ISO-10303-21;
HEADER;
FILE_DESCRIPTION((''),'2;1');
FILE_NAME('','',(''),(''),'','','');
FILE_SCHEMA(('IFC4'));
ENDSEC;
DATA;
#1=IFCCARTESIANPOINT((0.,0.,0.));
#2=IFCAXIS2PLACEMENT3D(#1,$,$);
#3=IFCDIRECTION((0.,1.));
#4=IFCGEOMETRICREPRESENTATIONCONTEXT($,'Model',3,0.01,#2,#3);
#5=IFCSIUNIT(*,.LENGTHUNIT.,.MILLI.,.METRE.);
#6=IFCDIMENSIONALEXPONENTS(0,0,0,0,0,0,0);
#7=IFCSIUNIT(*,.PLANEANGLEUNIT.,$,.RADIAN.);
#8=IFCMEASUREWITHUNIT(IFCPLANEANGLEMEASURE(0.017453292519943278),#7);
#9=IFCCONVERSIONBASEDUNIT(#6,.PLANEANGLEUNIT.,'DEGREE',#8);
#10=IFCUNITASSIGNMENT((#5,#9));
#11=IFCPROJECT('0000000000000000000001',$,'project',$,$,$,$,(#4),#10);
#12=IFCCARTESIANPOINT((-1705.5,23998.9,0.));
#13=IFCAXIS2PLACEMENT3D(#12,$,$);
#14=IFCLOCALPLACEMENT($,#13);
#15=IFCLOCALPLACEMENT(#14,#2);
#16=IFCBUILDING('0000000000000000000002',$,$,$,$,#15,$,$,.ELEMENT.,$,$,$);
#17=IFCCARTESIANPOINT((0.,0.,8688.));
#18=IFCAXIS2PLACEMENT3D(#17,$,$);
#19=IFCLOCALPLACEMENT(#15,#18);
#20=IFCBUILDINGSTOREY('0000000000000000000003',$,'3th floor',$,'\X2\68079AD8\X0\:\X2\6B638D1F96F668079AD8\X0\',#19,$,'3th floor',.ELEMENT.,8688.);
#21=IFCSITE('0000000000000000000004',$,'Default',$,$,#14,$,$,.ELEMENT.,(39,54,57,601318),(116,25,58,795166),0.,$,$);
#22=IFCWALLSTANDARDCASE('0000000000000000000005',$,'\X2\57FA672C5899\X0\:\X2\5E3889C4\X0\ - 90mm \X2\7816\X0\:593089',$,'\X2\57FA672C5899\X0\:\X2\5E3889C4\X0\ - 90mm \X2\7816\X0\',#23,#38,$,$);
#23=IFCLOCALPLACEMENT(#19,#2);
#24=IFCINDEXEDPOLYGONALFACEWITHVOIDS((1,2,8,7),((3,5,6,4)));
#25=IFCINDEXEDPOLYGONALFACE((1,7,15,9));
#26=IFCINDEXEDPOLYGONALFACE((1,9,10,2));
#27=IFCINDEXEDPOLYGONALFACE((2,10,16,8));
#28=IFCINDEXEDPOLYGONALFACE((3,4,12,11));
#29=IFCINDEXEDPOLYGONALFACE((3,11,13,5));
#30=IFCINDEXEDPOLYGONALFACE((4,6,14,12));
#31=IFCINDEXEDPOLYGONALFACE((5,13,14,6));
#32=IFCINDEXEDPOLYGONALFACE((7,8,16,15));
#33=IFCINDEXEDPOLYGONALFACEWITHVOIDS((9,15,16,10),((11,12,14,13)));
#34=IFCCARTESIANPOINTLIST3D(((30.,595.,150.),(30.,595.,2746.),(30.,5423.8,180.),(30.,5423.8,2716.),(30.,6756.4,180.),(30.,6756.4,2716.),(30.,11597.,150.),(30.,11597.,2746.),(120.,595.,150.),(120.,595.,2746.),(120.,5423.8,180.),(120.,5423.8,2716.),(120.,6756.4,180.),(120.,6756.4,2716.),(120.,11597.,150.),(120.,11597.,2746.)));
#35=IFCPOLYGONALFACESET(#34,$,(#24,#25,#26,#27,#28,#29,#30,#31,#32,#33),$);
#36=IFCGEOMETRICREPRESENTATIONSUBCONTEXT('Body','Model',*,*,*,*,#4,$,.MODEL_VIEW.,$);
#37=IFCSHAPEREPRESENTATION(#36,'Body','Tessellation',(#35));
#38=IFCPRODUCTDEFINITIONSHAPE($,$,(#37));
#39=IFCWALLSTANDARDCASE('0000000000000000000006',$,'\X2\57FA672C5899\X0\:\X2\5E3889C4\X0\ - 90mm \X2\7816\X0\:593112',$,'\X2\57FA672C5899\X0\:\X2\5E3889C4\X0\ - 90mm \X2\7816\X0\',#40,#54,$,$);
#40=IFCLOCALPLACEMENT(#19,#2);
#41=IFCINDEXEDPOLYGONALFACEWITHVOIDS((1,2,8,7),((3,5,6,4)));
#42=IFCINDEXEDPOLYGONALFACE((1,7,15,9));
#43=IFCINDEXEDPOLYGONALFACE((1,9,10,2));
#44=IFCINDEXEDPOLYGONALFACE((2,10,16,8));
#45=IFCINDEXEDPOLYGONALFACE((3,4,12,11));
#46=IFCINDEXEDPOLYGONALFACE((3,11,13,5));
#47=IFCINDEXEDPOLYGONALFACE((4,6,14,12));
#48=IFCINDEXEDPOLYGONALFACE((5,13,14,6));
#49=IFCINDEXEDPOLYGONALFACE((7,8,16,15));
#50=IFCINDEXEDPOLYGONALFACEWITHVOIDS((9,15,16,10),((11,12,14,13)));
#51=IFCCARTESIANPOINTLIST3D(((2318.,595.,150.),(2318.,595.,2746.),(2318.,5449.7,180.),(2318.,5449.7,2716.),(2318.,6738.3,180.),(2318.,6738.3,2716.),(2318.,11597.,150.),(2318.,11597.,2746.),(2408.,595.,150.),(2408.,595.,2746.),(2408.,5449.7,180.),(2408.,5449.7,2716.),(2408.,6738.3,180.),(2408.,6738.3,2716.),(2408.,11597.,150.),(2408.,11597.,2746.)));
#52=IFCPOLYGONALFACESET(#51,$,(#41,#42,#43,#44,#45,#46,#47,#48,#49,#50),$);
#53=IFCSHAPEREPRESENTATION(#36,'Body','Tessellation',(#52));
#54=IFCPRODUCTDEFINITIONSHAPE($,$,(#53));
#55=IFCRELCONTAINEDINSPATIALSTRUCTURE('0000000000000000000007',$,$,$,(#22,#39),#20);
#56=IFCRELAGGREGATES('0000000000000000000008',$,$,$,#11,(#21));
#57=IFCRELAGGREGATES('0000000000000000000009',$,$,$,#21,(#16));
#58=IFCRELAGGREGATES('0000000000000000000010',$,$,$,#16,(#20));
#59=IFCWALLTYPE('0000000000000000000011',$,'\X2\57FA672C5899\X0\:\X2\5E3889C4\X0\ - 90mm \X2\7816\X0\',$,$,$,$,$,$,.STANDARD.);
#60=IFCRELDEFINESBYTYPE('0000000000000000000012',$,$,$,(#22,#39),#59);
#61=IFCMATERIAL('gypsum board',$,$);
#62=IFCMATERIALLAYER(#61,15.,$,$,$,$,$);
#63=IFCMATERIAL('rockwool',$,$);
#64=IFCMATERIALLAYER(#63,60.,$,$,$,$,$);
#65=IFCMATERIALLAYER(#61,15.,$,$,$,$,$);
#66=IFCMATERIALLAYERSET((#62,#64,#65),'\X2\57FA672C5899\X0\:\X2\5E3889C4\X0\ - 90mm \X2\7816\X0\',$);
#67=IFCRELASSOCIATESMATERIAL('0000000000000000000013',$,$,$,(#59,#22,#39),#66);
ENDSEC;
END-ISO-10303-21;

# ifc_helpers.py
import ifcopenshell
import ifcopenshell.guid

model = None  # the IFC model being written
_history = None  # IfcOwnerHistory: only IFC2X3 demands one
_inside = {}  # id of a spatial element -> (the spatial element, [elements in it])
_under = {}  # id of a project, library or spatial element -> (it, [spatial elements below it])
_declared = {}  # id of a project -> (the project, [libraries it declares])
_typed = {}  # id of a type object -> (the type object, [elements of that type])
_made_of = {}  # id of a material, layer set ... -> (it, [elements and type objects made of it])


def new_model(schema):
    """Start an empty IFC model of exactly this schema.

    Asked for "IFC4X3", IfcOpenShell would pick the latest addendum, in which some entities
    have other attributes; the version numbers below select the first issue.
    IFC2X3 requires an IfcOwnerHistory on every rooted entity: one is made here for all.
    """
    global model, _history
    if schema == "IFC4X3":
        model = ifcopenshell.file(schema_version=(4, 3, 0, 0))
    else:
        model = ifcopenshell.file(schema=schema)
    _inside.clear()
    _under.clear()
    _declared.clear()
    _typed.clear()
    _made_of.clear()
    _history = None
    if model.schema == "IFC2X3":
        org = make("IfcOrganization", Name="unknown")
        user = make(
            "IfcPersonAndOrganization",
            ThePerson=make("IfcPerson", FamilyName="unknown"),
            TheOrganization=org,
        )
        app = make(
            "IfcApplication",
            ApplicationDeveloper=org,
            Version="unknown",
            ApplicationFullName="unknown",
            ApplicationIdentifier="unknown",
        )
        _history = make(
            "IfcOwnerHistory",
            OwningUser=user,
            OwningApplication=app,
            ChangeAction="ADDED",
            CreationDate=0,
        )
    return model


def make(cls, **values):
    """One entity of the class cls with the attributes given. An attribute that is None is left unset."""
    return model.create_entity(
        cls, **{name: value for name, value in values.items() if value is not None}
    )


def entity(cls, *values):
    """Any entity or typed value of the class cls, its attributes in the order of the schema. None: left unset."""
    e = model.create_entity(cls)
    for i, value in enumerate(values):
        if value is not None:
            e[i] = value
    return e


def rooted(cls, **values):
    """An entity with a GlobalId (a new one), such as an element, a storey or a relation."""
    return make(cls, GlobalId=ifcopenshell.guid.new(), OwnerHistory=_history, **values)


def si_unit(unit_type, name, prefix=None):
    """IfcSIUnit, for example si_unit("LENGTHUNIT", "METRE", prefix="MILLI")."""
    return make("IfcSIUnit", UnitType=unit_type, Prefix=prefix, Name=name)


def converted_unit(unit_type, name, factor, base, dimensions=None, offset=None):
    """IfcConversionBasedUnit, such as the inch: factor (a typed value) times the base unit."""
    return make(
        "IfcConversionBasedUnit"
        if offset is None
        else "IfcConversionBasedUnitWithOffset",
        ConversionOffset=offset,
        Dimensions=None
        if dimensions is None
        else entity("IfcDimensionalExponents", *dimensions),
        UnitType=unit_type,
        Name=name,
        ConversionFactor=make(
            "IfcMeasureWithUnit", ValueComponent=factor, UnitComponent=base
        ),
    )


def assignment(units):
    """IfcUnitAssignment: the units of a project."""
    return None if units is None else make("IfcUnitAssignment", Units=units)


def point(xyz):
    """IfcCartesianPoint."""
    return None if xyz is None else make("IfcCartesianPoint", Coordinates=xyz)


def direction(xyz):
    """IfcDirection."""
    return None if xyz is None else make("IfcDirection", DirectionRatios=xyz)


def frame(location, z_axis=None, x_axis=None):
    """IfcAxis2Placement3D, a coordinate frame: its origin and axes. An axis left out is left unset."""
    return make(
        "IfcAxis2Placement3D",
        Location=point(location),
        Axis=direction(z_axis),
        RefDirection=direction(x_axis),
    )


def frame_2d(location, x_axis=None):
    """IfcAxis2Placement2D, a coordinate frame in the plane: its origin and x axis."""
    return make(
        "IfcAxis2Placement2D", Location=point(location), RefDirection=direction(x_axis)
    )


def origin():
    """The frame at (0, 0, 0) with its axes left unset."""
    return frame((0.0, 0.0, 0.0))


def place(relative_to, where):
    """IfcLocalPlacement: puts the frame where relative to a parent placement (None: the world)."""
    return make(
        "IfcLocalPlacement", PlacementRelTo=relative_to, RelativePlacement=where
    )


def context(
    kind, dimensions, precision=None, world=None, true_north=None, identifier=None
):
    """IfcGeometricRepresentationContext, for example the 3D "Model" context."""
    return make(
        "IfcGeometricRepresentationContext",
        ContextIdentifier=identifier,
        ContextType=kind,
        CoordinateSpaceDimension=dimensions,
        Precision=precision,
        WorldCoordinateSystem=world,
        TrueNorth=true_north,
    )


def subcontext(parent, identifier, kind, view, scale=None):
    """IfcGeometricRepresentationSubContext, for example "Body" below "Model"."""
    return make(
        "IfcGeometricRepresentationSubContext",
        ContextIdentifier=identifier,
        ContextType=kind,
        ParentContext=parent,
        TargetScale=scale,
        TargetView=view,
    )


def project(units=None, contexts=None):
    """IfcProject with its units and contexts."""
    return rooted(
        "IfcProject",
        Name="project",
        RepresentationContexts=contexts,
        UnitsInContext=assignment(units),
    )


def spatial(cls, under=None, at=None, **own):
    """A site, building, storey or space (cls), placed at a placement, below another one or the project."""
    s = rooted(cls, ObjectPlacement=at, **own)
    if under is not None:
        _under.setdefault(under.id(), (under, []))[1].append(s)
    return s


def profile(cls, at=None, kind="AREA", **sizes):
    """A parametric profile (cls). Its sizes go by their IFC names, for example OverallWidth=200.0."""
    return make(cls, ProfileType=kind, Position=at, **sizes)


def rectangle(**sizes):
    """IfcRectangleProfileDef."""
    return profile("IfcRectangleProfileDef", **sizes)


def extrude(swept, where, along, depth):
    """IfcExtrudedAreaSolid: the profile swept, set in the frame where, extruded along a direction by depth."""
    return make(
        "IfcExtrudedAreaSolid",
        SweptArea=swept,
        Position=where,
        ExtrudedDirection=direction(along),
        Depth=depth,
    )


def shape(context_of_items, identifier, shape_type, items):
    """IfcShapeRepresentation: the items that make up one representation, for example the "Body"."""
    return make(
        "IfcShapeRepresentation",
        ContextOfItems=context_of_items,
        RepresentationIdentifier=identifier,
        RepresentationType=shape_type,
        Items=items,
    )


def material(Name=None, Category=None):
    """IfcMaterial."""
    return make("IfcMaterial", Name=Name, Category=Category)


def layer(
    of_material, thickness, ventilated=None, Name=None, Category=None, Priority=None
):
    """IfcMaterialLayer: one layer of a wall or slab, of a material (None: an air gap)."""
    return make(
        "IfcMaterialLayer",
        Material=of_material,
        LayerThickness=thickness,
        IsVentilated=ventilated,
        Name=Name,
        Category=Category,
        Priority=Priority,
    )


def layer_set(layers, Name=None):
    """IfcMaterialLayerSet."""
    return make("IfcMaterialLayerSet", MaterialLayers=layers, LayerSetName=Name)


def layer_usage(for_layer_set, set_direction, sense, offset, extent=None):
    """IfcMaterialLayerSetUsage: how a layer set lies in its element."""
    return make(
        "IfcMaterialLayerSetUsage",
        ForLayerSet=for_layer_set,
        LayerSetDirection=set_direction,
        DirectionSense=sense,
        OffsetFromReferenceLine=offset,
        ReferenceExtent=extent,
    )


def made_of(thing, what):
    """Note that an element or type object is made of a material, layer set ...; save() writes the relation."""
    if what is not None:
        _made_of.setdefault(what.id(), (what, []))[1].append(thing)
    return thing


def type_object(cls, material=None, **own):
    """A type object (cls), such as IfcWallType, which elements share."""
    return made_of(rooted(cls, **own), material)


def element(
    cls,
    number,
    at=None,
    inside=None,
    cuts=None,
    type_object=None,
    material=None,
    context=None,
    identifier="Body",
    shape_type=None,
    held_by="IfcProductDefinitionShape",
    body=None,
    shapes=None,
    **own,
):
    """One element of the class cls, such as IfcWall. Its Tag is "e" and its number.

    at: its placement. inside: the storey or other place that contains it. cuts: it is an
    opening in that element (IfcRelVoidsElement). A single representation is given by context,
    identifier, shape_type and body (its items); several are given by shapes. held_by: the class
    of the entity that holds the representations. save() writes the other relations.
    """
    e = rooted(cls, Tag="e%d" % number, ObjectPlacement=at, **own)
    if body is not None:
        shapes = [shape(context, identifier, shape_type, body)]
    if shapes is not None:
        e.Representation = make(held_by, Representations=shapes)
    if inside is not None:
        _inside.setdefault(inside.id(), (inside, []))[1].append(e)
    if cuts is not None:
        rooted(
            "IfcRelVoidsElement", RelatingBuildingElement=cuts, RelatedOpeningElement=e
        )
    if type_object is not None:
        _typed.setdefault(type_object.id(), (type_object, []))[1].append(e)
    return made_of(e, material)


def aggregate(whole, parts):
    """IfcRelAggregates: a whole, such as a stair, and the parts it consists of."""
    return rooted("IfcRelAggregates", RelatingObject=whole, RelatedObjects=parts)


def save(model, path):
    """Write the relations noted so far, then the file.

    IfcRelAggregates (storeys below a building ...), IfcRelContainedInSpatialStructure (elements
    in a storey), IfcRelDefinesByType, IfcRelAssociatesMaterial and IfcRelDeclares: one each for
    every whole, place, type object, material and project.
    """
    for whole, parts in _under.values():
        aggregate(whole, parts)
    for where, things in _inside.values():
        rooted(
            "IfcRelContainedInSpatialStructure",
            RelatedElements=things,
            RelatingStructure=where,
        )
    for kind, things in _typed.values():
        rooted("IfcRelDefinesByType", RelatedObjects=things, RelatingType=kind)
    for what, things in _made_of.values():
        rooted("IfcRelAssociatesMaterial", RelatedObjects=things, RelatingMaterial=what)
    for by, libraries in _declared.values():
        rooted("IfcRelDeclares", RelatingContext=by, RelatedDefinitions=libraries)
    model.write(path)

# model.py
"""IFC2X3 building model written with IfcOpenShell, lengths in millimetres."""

from ifc_helpers import new_model, entity, si_unit, converted_unit, direction, frame, frame_2d, origin, place, context, subcontext, project, spatial, rectangle, extrude, material, layer, layer_set, layer_usage, type_object, element, save


model = new_model("IFC2X3")

# Units and contexts
model_context = context("Model", 3, precision=0.01, world=origin(), true_north=direction((0.0, 1.0)))
body_context = subcontext(model_context, "Body", "Model", "MODEL_VIEW")
ifc_project = project(units=[si_unit("LENGTHUNIT", "METRE", prefix="MILLI"), converted_unit("PLANEANGLEUNIT", "DEGREE", entity("IfcPlaneAngleMeasure", 0.017453292519943278), si_unit("PLANEANGLEUNIT", "RADIAN"), dimensions=[0, 0, 0, 0, 0, 0, 0])], contexts=[model_context])

# Site, building, storey
site_placement = place(None, frame((-1705.5, 23998.9, 0.0)))
site = spatial("IfcSite", under=ifc_project, at=site_placement, Name="Default", CompositionType="ELEMENT", RefLatitude=(39, 54, 57, 601318), RefLongitude=(116, 25, 58, 795166), RefElevation=0.0)
building_placement = place(site_placement, origin())
building = spatial("IfcBuilding", under=site, at=building_placement, CompositionType="ELEMENT")
storey_placement = place(building_placement, frame((0.0, 0.0, 8688.0)))
storey = spatial("IfcBuildingStorey", under=building, at=storey_placement, Name="3th floor", ObjectType="标高:正负零标高", LongName="3th floor", CompositionType="ELEMENT", Elevation=8688.0)

# Wall, opening
ifc_material_1 = material(Name="gypsum board")
ifc_layer_1 = layer(ifc_material_1, 15.0)
ifc_material_2 = material(Name="rockwool")
ifc_layer_2 = layer(ifc_material_2, 60.0)
ifc_layer_3 = layer(ifc_material_1, 15.0)
ifc_layer_set = layer_set([ifc_layer_1, ifc_layer_2, ifc_layer_3], Name="基本墙:常规 - 90mm 砖")
ifc_layer_usage_1 = layer_usage(ifc_layer_set, "AXIS2", "NEGATIVE", 45.0)
wall_type = type_object("IfcWallType", Name="基本墙:常规 - 90mm 砖", PredefinedType="STANDARD", material=ifc_layer_set)
wall_1_placement = place(storey_placement, frame((75.0, 11597.0, 150.0), z_axis=(0.0, 0.0, 1.0), x_axis=(0.0, -1.0, 0.0)))
wall_1 = element("IfcWallStandardCase", 1, at=wall_1_placement, inside=storey, type_object=wall_type, material=ifc_layer_usage_1, Name="基本墙:常规 - 90mm 砖:593089", ObjectType="基本墙:常规 - 90mm 砖", context=body_context, shape_type="SweptSolid", body=[
    extrude(rectangle(XDim=11002.0, YDim=90.0, at=frame_2d((5501.0, 0.0), x_axis=(-1.0, 0.0))), origin(), (0.0, 0.0, 1.0), 2596.0),
])
opening_1_placement = place(wall_1_placement, origin())
element("IfcOpeningElement", 2, at=opening_1_placement, cuts=wall_1, ObjectType="Opening", context=body_context, shape_type="SweptSolid", body=[
    extrude(rectangle(XDim=2536.0, YDim=1332.6, at=frame_2d((0.0, 0.0), x_axis=(0.0, 1.0))), frame((5506.9, 45.0, 1298.0), z_axis=(0.0, -1.0, 0.0), x_axis=(-1.0, 0.0, 0.0)), (0.0, 0.0, 1.0), 90.0),
])

# Wall, opening
ifc_layer_usage_2 = layer_usage(ifc_layer_set, "AXIS2", "NEGATIVE", 45.0)
wall_2_placement = place(storey_placement, frame((2363.0, 11597.0, 150.0), z_axis=(0.0, 0.0, 1.0), x_axis=(0.0, -1.0, 0.0)))
wall_2 = element("IfcWallStandardCase", 3, at=wall_2_placement, inside=storey, type_object=wall_type, material=ifc_layer_usage_2, Name="基本墙:常规 - 90mm 砖:593112", ObjectType="基本墙:常规 - 90mm 砖", context=body_context, shape_type="SweptSolid", body=[
    extrude(rectangle(XDim=11002.0, YDim=90.0, at=frame_2d((5501.0, 0.0), x_axis=(-1.0, 0.0))), origin(), (0.0, 0.0, 1.0), 2596.0),
])
opening_2_placement = place(wall_2_placement, origin())
element("IfcOpeningElement", 4, at=opening_2_placement, cuts=wall_2, ObjectType="Opening", context=body_context, shape_type="SweptSolid", body=[
    extrude(rectangle(XDim=2536.0, YDim=1288.6, at=frame_2d((0.0, 0.0), x_axis=(0.0, 1.0))), frame((5503.0, 45.0, 1298.0), z_axis=(0.0, -1.0, 0.0), x_axis=(-1.0, 0.0, 0.0)), (0.0, 0.0, 1.0), 90.0),
])

save(model, "model.ifc")
